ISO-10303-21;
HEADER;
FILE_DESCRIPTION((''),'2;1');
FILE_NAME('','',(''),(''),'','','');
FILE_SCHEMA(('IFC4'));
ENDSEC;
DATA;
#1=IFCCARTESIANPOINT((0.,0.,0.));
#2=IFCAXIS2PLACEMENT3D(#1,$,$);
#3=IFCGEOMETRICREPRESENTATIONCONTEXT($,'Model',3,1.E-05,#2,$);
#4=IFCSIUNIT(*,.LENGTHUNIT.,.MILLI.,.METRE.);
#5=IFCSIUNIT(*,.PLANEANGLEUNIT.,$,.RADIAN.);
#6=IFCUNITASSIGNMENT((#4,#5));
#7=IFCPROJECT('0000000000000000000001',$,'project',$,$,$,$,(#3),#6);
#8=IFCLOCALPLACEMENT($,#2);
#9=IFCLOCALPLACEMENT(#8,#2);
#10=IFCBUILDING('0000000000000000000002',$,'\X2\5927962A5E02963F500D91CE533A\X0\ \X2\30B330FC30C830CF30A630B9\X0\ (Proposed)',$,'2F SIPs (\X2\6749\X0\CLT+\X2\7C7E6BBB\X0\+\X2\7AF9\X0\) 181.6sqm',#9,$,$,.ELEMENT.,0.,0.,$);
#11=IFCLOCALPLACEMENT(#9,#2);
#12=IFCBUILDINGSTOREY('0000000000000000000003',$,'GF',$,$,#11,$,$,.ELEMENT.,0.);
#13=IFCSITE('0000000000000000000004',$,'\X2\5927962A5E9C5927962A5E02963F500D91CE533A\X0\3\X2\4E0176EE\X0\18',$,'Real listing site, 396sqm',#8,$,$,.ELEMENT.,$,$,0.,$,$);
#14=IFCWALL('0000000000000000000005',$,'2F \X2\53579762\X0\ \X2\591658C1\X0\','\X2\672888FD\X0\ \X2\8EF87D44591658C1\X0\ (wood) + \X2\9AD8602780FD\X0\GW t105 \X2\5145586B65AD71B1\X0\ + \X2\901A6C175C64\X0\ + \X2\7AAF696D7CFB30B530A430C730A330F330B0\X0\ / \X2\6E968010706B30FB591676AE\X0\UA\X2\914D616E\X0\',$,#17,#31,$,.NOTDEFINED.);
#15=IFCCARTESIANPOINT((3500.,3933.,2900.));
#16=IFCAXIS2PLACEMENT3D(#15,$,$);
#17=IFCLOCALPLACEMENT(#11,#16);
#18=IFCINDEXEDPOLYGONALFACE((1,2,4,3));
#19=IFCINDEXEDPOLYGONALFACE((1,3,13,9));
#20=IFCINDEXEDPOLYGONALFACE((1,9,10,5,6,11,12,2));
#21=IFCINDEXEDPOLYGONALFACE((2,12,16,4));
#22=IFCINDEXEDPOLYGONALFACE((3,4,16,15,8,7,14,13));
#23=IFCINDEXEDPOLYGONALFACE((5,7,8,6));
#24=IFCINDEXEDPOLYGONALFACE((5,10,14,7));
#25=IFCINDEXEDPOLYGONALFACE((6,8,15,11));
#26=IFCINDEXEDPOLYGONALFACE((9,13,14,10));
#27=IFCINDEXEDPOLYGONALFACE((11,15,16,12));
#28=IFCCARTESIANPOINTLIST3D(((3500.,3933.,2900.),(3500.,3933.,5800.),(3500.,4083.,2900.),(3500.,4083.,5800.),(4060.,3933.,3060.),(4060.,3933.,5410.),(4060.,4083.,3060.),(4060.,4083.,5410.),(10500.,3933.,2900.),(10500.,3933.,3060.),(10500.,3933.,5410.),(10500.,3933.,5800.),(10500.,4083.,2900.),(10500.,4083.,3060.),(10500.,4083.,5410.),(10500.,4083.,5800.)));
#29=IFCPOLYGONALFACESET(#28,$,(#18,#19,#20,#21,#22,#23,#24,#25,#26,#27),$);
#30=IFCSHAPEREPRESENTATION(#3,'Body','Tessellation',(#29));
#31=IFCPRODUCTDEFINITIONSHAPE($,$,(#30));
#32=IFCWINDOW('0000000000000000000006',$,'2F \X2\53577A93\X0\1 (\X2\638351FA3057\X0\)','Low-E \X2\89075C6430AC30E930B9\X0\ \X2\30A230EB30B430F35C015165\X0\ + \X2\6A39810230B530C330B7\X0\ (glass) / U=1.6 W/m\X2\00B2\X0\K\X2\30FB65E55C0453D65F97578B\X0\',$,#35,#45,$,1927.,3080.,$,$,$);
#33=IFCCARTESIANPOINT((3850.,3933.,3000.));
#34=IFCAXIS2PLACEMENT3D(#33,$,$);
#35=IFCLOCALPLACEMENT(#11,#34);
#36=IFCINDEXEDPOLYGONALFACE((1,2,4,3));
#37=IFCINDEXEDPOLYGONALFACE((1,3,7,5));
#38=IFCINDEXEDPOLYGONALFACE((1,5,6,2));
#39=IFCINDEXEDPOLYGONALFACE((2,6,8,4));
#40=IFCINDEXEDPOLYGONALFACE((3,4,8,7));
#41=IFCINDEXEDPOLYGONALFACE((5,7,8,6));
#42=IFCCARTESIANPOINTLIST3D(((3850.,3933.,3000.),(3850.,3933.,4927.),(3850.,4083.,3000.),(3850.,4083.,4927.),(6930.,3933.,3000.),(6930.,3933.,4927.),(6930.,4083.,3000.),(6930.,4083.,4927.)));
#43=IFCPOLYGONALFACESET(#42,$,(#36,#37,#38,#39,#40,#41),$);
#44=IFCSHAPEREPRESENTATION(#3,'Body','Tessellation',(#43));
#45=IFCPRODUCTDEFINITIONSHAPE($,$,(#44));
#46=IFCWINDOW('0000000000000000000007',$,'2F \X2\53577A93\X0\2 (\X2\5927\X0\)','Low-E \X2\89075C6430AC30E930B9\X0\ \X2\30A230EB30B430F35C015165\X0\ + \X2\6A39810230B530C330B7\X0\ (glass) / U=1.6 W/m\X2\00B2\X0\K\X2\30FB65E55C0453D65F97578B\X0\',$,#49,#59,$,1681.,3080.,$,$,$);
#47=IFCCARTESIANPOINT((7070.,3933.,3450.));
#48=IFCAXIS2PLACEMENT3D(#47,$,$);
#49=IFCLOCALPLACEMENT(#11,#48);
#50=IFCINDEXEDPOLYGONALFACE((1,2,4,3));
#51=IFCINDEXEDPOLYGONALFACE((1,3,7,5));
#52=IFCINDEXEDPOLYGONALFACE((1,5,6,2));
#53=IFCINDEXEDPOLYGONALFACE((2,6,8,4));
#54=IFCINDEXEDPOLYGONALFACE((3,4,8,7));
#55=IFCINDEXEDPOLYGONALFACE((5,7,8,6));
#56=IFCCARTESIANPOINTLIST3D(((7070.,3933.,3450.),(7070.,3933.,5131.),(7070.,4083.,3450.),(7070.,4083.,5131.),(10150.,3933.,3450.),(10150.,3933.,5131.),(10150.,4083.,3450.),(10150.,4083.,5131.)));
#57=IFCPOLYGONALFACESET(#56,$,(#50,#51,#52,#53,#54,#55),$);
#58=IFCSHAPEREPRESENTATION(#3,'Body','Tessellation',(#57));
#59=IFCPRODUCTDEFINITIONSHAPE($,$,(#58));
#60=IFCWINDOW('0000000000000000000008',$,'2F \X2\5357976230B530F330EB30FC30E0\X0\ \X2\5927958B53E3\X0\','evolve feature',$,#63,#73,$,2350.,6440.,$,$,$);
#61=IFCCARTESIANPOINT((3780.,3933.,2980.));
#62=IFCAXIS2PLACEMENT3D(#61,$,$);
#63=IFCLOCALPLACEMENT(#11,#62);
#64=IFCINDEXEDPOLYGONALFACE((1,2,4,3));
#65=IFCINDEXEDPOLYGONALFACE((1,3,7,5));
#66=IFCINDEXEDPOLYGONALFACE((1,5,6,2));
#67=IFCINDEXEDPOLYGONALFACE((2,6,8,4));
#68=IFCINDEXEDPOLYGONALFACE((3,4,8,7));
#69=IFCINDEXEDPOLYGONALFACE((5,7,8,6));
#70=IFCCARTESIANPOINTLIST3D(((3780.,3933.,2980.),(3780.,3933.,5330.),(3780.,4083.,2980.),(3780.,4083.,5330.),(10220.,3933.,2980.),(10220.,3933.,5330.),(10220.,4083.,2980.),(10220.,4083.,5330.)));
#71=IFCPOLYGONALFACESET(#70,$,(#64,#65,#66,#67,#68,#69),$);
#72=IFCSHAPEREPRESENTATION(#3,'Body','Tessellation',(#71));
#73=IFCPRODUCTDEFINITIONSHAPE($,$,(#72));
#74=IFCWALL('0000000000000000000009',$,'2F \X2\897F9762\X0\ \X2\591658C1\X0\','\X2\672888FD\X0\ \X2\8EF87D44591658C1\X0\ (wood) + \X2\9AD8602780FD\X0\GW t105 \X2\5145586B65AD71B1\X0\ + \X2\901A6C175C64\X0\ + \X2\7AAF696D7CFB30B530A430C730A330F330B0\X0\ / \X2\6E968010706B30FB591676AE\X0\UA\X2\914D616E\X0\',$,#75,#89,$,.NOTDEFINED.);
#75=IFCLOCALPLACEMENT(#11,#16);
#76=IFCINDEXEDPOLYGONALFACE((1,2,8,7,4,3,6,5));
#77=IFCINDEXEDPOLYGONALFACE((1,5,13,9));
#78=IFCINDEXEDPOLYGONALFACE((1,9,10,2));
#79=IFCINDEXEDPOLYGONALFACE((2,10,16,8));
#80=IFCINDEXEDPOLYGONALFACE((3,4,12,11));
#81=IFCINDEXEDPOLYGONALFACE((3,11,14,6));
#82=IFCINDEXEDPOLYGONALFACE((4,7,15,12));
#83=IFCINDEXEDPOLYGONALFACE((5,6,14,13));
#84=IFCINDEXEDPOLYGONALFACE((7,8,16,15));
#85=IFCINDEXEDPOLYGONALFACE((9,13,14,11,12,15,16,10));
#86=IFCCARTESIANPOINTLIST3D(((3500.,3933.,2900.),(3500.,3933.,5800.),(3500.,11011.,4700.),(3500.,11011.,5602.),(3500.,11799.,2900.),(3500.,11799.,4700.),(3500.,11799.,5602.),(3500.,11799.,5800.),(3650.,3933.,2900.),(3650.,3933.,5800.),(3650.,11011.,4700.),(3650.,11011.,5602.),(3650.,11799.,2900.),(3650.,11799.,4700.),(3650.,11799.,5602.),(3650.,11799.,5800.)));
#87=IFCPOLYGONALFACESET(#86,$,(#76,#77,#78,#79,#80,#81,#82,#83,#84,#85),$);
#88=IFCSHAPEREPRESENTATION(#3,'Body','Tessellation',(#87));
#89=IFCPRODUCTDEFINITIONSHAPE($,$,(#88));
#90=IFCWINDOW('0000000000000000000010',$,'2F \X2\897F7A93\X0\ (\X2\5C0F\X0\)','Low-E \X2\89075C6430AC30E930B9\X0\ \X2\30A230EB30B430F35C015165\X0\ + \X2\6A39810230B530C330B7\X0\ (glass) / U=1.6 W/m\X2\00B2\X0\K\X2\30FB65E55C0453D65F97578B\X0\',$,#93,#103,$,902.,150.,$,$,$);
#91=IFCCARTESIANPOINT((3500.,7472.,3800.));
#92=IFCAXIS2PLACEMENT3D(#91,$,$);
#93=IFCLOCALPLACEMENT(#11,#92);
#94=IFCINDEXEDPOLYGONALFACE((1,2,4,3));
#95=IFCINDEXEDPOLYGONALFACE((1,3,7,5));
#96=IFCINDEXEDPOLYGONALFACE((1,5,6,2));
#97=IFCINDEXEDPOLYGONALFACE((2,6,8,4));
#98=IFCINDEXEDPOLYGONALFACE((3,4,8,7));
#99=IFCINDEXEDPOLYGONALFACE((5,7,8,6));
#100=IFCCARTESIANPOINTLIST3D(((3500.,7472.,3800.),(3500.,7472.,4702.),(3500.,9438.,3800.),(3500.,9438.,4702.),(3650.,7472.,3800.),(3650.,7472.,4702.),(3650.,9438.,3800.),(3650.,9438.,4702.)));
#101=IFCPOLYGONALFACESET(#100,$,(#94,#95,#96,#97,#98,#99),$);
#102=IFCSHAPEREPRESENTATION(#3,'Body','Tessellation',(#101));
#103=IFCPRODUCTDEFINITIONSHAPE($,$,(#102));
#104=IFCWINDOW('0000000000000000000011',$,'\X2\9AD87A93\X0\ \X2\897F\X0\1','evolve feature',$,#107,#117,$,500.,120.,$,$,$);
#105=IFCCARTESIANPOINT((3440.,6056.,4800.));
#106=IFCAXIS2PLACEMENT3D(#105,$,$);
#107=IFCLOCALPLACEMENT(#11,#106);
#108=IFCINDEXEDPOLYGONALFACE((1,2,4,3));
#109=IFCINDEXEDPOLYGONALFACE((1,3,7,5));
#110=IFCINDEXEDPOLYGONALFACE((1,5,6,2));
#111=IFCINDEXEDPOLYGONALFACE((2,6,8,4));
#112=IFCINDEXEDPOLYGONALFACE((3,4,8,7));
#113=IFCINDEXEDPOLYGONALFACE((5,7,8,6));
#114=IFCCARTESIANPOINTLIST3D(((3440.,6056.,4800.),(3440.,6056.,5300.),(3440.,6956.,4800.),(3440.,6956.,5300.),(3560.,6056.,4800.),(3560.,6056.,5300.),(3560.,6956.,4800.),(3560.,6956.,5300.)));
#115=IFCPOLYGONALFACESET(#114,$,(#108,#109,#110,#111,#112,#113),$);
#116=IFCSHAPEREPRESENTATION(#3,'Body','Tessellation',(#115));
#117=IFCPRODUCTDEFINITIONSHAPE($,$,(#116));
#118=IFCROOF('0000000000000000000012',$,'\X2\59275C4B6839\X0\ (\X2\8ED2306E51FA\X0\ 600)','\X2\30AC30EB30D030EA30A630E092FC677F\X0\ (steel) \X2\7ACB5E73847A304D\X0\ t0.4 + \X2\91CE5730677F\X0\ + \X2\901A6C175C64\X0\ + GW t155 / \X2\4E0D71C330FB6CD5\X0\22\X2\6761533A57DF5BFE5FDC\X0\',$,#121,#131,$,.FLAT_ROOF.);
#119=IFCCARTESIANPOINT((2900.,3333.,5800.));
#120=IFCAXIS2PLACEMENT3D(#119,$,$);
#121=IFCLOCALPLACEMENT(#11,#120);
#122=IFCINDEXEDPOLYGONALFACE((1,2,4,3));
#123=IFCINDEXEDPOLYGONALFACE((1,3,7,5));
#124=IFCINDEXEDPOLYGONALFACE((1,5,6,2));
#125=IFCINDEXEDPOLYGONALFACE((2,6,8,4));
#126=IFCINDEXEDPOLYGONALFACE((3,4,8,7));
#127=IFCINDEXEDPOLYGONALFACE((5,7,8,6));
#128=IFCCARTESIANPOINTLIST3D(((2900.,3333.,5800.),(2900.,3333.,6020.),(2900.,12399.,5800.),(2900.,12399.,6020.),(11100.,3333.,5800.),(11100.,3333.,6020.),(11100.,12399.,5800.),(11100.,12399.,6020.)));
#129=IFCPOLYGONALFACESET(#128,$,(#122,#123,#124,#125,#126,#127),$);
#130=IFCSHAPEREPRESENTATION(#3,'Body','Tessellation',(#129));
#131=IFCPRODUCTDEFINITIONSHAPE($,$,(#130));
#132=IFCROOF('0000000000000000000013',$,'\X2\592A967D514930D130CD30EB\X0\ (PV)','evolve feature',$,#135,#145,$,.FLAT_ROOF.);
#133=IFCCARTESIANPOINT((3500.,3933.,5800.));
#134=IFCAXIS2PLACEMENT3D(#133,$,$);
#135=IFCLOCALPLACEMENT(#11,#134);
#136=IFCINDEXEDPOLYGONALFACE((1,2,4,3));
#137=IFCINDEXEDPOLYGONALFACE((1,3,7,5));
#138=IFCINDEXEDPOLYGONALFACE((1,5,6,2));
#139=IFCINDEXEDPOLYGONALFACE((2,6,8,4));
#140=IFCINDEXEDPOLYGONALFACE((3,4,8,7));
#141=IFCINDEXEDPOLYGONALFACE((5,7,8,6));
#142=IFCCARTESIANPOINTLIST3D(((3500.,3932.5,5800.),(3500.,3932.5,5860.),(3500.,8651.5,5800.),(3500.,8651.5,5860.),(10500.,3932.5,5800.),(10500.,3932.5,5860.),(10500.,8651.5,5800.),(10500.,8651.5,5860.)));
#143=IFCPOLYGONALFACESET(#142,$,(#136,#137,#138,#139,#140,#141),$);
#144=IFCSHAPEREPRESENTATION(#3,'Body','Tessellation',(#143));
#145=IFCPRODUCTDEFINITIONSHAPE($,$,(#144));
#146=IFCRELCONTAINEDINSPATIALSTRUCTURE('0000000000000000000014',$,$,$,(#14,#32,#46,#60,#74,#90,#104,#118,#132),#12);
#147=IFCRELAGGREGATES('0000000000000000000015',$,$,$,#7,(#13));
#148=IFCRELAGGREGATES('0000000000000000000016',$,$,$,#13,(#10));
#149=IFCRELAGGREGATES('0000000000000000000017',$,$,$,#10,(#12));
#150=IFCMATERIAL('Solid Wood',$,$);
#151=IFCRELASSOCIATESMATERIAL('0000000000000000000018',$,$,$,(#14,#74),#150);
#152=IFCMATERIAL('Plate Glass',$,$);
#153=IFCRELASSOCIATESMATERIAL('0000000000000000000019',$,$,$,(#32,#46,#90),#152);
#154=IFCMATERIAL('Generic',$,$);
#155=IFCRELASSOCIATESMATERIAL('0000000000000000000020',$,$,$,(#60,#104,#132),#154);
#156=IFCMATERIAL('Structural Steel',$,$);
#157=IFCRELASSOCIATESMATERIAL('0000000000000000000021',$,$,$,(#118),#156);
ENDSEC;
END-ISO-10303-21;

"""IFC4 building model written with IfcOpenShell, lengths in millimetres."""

from ifc_helpers import new_model, si_unit, frame, frame_2d, origin, place, context, project, spatial, rectangle, extrude, material, element, fill, save


model = new_model("IFC4")

# Units and contexts
model_context = context("Model", 3, precision=1e-05, world=origin())
ifc_project = project(units=[si_unit("LENGTHUNIT", "METRE", prefix="MILLI"), si_unit("PLANEANGLEUNIT", "RADIAN")], contexts=[model_context])

# Site, building, storey
site_placement = place(None, origin())
site = spatial("IfcSite", under=ifc_project, at=site_placement, Name="大阪府大阪市阿倍野区3丁目18", ObjectType="Real listing site, 396sqm", CompositionType="ELEMENT", RefElevation=0.0)
building_placement = place(site_placement, origin())
building = spatial("IfcBuilding", under=site, at=building_placement, Name="大阪市阿倍野区 コートハウス (Proposed)", ObjectType="2F SIPs (杉CLT+籾殻+竹) 181.6sqm", CompositionType="ELEMENT", ElevationOfRefHeight=0.0, ElevationOfTerrain=0.0)
storey_placement = place(building_placement, origin())
storey = spatial("IfcBuildingStorey", under=building, at=storey_placement, Name="GF", CompositionType="ELEMENT", Elevation=0.0)

# Shared definitions
ifc_material_1 = material(Name="Solid Wood")
ifc_material_2 = material(Name="Generic")

# Shared definitions
ifc_material_3 = material(Name="Plate Glass")

# Walls, openings, windows
wall_1_placement = place(storey_placement, frame((3500.0, 3933.0, 2900.0)))
wall_1 = element("IfcWall", 1, at=wall_1_placement, inside=storey, material=ifc_material_1, Name="2F 南面 外壁", Description="木製 軸組外壁 (wood) + 高性能GW t105 充填断熱 + 通気層 + 窯業系サイディング / 準耐火・外皮UA配慮", PredefinedType="NOTDEFINED", context=model_context, shape_type="SweptSolid", body=[
    extrude(rectangle(XDim=7000.0, YDim=150.0, at=frame_2d((3500.0, 75.0))), frame((3500.0, 3933.0, 2900.0)), (0.0, 0.0, 1.0), 2900.0),
])
opening_1_placement = place(storey_placement, frame((3850.0, 3933.0, 3000.0)))
opening_1 = element("IfcOpeningElement", 2, at=opening_1_placement, cuts=wall_1, PredefinedType="NOTDEFINED", context=model_context, shape_type="SweptSolid", body=[
    extrude(rectangle(XDim=3080.0, YDim=150.0, at=frame_2d((1540.0, 75.0))), frame((3850.0, 3933.0, 3000.0)), (0.0, 0.0, 1.0), 1927.0),
])
opening_2_placement = place(storey_placement, frame((7070.0, 3933.0, 3450.0)))
opening_2 = element("IfcOpeningElement", 3, at=opening_2_placement, cuts=wall_1, PredefinedType="NOTDEFINED", context=model_context, shape_type="SweptSolid", body=[
    extrude(rectangle(XDim=3080.0, YDim=150.0, at=frame_2d((1540.0, 75.0))), frame((7070.0, 3933.0, 3450.0)), (0.0, 0.0, 1.0), 1681.0),
])
opening_3_placement = place(storey_placement, frame((3780.0, 3933.0, 2980.0)))
opening_3 = element("IfcOpeningElement", 4, at=opening_3_placement, cuts=wall_1, PredefinedType="NOTDEFINED", context=model_context, shape_type="SweptSolid", body=[
    extrude(rectangle(XDim=6440.0, YDim=150.0, at=frame_2d((3220.0, 75.0))), frame((3780.0, 3933.0, 2980.0)), (0.0, 0.0, 1.0), 2350.0),
])
window_1_placement = place(storey_placement, frame((3850.0, 3933.0, 3000.0)))
window_1 = element("IfcWindow", 5, at=window_1_placement, inside=storey, material=ifc_material_3, Name="2F 南窓1 (掃出し)", Description="Low-E 複層ガラス アルゴン封入 + 樹脂サッシ (glass) / U=1.6 W/m²K・日射取得型", OverallHeight=1927.0, OverallWidth=3080.0, context=model_context, shape_type="SweptSolid", body=[
    extrude(rectangle(XDim=3080.0, YDim=150.0, at=frame_2d((1540.0, 75.0))), frame((3850.0, 3933.0, 3000.0)), (0.0, 0.0, 1.0), 1927.0),
])
fill(opening_1, window_1)
window_2_placement = place(storey_placement, frame((7070.0, 3933.0, 3450.0)))
window_2 = element("IfcWindow", 6, at=window_2_placement, inside=storey, material=ifc_material_3, Name="2F 南窓2 (大)", Description="Low-E 複層ガラス アルゴン封入 + 樹脂サッシ (glass) / U=1.6 W/m²K・日射取得型", OverallHeight=1681.0, OverallWidth=3080.0, context=model_context, shape_type="SweptSolid", body=[
    extrude(rectangle(XDim=3080.0, YDim=150.0, at=frame_2d((1540.0, 75.0))), frame((7070.0, 3933.0, 3450.0)), (0.0, 0.0, 1.0), 1681.0),
])
fill(opening_2, window_2)
window_3_placement = place(storey_placement, frame((3780.0, 3933.0, 2980.0)))
window_3 = element("IfcWindow", 7, at=window_3_placement, inside=storey, material=ifc_material_2, Name="2F 南面サンルーム 大開口", Description="evolve feature", OverallHeight=2350.0, OverallWidth=6440.0, context=model_context, shape_type="SweptSolid", body=[
    extrude(rectangle(XDim=6440.0, YDim=150.0, at=frame_2d((3220.0, 75.0))), frame((3780.0, 3933.0, 2980.0)), (0.0, 0.0, 1.0), 2350.0),
])
fill(opening_3, window_3)
wall_2_placement = place(storey_placement, frame((3500.0, 3933.0, 2900.0)))
wall_2 = element("IfcWall", 8, at=wall_2_placement, inside=storey, material=ifc_material_1, Name="2F 西面 外壁", Description="木製 軸組外壁 (wood) + 高性能GW t105 充填断熱 + 通気層 + 窯業系サイディング / 準耐火・外皮UA配慮", PredefinedType="NOTDEFINED", context=model_context, shape_type="SweptSolid", body=[
    extrude(rectangle(XDim=150.0, YDim=7866.0, at=frame_2d((75.0, 3933.0))), frame((3500.0, 3933.0, 2900.0)), (0.0, 0.0, 1.0), 2900.0),
])
opening_4_placement = place(storey_placement, frame((3500.0, 7472.0, 3800.0)))
opening_4 = element("IfcOpeningElement", 9, at=opening_4_placement, cuts=wall_2, PredefinedType="NOTDEFINED", context=model_context, shape_type="SweptSolid", body=[
    extrude(rectangle(XDim=150.0, YDim=1966.0, at=frame_2d((75.0, 983.0))), frame((3500.0, 7472.0, 3800.0)), (0.0, 0.0, 1.0), 902.0),
])
opening_5_placement = place(storey_placement, frame((3440.0, 6056.0, 4800.0)))
opening_5 = element("IfcOpeningElement", 10, at=opening_5_placement, cuts=wall_2, PredefinedType="NOTDEFINED", context=model_context, shape_type="SweptSolid", body=[
    extrude(rectangle(XDim=120.0, YDim=900.0, at=frame_2d((60.0, 450.0))), frame((3440.0, 6056.0, 4800.0)), (0.0, 0.0, 1.0), 500.0),
])
window_4_placement = place(storey_placement, frame((3500.0, 7472.0, 3800.0)))
window_4 = element("IfcWindow", 11, at=window_4_placement, inside=storey, material=ifc_material_3, Name="2F 西窓 (小)", Description="Low-E 複層ガラス アルゴン封入 + 樹脂サッシ (glass) / U=1.6 W/m²K・日射取得型", OverallHeight=902.0, OverallWidth=150.0, context=model_context, shape_type="SweptSolid", body=[
    extrude(rectangle(XDim=150.0, YDim=1966.0, at=frame_2d((75.0, 983.0))), frame((3500.0, 7472.0, 3800.0)), (0.0, 0.0, 1.0), 902.0),
])
fill(opening_4, window_4)
window_5_placement = place(storey_placement, frame((3440.0, 6056.0, 4800.0)))
window_5 = element("IfcWindow", 12, at=window_5_placement, inside=storey, material=ifc_material_2, Name="高窓 西1", Description="evolve feature", OverallHeight=500.0, OverallWidth=120.0, context=model_context, shape_type="SweptSolid", body=[
    extrude(rectangle(XDim=120.0, YDim=900.0, at=frame_2d((60.0, 450.0))), frame((3440.0, 6056.0, 4800.0)), (0.0, 0.0, 1.0), 500.0),
])
fill(opening_5, window_5)

# Roofs
ifc_material_4 = material(Name="Structural Steel")
roof_1_placement = place(storey_placement, frame((2900.0, 3333.0, 5800.0)))
element("IfcRoof", 13, at=roof_1_placement, inside=storey, material=ifc_material_4, Name="大屋根 (軒の出 600)", Description="ガルバリウム鋼板 (steel) 立平葺き t0.4 + 野地板 + 通気層 + GW t155 / 不燃・法22条区域対応", PredefinedType="FLAT_ROOF", context=model_context, shape_type="SweptSolid", body=[
    extrude(rectangle(XDim=8200.0, YDim=9066.0, at=frame_2d((4100.0, 4533.0))), frame((2900.0, 3333.0, 5800.0)), (0.0, 0.0, 1.0), 220.0),
])
roof_2_placement = place(storey_placement, frame((3500.0, 3933.0, 5800.0)))
element("IfcRoof", 14, at=roof_2_placement, inside=storey, material=ifc_material_2, Name="太陽光パネル (PV)", Description="evolve feature", PredefinedType="FLAT_ROOF", context=model_context, shape_type="SweptSolid", body=[
    extrude(rectangle(XDim=7000.0, YDim=4719.0, at=frame_2d((3500.0, 2359.0))), frame((3500.0, 3933.0, 5800.0)), (0.0, 0.0, 1.0), 60.0),
])

save(model, "model.ifc")
